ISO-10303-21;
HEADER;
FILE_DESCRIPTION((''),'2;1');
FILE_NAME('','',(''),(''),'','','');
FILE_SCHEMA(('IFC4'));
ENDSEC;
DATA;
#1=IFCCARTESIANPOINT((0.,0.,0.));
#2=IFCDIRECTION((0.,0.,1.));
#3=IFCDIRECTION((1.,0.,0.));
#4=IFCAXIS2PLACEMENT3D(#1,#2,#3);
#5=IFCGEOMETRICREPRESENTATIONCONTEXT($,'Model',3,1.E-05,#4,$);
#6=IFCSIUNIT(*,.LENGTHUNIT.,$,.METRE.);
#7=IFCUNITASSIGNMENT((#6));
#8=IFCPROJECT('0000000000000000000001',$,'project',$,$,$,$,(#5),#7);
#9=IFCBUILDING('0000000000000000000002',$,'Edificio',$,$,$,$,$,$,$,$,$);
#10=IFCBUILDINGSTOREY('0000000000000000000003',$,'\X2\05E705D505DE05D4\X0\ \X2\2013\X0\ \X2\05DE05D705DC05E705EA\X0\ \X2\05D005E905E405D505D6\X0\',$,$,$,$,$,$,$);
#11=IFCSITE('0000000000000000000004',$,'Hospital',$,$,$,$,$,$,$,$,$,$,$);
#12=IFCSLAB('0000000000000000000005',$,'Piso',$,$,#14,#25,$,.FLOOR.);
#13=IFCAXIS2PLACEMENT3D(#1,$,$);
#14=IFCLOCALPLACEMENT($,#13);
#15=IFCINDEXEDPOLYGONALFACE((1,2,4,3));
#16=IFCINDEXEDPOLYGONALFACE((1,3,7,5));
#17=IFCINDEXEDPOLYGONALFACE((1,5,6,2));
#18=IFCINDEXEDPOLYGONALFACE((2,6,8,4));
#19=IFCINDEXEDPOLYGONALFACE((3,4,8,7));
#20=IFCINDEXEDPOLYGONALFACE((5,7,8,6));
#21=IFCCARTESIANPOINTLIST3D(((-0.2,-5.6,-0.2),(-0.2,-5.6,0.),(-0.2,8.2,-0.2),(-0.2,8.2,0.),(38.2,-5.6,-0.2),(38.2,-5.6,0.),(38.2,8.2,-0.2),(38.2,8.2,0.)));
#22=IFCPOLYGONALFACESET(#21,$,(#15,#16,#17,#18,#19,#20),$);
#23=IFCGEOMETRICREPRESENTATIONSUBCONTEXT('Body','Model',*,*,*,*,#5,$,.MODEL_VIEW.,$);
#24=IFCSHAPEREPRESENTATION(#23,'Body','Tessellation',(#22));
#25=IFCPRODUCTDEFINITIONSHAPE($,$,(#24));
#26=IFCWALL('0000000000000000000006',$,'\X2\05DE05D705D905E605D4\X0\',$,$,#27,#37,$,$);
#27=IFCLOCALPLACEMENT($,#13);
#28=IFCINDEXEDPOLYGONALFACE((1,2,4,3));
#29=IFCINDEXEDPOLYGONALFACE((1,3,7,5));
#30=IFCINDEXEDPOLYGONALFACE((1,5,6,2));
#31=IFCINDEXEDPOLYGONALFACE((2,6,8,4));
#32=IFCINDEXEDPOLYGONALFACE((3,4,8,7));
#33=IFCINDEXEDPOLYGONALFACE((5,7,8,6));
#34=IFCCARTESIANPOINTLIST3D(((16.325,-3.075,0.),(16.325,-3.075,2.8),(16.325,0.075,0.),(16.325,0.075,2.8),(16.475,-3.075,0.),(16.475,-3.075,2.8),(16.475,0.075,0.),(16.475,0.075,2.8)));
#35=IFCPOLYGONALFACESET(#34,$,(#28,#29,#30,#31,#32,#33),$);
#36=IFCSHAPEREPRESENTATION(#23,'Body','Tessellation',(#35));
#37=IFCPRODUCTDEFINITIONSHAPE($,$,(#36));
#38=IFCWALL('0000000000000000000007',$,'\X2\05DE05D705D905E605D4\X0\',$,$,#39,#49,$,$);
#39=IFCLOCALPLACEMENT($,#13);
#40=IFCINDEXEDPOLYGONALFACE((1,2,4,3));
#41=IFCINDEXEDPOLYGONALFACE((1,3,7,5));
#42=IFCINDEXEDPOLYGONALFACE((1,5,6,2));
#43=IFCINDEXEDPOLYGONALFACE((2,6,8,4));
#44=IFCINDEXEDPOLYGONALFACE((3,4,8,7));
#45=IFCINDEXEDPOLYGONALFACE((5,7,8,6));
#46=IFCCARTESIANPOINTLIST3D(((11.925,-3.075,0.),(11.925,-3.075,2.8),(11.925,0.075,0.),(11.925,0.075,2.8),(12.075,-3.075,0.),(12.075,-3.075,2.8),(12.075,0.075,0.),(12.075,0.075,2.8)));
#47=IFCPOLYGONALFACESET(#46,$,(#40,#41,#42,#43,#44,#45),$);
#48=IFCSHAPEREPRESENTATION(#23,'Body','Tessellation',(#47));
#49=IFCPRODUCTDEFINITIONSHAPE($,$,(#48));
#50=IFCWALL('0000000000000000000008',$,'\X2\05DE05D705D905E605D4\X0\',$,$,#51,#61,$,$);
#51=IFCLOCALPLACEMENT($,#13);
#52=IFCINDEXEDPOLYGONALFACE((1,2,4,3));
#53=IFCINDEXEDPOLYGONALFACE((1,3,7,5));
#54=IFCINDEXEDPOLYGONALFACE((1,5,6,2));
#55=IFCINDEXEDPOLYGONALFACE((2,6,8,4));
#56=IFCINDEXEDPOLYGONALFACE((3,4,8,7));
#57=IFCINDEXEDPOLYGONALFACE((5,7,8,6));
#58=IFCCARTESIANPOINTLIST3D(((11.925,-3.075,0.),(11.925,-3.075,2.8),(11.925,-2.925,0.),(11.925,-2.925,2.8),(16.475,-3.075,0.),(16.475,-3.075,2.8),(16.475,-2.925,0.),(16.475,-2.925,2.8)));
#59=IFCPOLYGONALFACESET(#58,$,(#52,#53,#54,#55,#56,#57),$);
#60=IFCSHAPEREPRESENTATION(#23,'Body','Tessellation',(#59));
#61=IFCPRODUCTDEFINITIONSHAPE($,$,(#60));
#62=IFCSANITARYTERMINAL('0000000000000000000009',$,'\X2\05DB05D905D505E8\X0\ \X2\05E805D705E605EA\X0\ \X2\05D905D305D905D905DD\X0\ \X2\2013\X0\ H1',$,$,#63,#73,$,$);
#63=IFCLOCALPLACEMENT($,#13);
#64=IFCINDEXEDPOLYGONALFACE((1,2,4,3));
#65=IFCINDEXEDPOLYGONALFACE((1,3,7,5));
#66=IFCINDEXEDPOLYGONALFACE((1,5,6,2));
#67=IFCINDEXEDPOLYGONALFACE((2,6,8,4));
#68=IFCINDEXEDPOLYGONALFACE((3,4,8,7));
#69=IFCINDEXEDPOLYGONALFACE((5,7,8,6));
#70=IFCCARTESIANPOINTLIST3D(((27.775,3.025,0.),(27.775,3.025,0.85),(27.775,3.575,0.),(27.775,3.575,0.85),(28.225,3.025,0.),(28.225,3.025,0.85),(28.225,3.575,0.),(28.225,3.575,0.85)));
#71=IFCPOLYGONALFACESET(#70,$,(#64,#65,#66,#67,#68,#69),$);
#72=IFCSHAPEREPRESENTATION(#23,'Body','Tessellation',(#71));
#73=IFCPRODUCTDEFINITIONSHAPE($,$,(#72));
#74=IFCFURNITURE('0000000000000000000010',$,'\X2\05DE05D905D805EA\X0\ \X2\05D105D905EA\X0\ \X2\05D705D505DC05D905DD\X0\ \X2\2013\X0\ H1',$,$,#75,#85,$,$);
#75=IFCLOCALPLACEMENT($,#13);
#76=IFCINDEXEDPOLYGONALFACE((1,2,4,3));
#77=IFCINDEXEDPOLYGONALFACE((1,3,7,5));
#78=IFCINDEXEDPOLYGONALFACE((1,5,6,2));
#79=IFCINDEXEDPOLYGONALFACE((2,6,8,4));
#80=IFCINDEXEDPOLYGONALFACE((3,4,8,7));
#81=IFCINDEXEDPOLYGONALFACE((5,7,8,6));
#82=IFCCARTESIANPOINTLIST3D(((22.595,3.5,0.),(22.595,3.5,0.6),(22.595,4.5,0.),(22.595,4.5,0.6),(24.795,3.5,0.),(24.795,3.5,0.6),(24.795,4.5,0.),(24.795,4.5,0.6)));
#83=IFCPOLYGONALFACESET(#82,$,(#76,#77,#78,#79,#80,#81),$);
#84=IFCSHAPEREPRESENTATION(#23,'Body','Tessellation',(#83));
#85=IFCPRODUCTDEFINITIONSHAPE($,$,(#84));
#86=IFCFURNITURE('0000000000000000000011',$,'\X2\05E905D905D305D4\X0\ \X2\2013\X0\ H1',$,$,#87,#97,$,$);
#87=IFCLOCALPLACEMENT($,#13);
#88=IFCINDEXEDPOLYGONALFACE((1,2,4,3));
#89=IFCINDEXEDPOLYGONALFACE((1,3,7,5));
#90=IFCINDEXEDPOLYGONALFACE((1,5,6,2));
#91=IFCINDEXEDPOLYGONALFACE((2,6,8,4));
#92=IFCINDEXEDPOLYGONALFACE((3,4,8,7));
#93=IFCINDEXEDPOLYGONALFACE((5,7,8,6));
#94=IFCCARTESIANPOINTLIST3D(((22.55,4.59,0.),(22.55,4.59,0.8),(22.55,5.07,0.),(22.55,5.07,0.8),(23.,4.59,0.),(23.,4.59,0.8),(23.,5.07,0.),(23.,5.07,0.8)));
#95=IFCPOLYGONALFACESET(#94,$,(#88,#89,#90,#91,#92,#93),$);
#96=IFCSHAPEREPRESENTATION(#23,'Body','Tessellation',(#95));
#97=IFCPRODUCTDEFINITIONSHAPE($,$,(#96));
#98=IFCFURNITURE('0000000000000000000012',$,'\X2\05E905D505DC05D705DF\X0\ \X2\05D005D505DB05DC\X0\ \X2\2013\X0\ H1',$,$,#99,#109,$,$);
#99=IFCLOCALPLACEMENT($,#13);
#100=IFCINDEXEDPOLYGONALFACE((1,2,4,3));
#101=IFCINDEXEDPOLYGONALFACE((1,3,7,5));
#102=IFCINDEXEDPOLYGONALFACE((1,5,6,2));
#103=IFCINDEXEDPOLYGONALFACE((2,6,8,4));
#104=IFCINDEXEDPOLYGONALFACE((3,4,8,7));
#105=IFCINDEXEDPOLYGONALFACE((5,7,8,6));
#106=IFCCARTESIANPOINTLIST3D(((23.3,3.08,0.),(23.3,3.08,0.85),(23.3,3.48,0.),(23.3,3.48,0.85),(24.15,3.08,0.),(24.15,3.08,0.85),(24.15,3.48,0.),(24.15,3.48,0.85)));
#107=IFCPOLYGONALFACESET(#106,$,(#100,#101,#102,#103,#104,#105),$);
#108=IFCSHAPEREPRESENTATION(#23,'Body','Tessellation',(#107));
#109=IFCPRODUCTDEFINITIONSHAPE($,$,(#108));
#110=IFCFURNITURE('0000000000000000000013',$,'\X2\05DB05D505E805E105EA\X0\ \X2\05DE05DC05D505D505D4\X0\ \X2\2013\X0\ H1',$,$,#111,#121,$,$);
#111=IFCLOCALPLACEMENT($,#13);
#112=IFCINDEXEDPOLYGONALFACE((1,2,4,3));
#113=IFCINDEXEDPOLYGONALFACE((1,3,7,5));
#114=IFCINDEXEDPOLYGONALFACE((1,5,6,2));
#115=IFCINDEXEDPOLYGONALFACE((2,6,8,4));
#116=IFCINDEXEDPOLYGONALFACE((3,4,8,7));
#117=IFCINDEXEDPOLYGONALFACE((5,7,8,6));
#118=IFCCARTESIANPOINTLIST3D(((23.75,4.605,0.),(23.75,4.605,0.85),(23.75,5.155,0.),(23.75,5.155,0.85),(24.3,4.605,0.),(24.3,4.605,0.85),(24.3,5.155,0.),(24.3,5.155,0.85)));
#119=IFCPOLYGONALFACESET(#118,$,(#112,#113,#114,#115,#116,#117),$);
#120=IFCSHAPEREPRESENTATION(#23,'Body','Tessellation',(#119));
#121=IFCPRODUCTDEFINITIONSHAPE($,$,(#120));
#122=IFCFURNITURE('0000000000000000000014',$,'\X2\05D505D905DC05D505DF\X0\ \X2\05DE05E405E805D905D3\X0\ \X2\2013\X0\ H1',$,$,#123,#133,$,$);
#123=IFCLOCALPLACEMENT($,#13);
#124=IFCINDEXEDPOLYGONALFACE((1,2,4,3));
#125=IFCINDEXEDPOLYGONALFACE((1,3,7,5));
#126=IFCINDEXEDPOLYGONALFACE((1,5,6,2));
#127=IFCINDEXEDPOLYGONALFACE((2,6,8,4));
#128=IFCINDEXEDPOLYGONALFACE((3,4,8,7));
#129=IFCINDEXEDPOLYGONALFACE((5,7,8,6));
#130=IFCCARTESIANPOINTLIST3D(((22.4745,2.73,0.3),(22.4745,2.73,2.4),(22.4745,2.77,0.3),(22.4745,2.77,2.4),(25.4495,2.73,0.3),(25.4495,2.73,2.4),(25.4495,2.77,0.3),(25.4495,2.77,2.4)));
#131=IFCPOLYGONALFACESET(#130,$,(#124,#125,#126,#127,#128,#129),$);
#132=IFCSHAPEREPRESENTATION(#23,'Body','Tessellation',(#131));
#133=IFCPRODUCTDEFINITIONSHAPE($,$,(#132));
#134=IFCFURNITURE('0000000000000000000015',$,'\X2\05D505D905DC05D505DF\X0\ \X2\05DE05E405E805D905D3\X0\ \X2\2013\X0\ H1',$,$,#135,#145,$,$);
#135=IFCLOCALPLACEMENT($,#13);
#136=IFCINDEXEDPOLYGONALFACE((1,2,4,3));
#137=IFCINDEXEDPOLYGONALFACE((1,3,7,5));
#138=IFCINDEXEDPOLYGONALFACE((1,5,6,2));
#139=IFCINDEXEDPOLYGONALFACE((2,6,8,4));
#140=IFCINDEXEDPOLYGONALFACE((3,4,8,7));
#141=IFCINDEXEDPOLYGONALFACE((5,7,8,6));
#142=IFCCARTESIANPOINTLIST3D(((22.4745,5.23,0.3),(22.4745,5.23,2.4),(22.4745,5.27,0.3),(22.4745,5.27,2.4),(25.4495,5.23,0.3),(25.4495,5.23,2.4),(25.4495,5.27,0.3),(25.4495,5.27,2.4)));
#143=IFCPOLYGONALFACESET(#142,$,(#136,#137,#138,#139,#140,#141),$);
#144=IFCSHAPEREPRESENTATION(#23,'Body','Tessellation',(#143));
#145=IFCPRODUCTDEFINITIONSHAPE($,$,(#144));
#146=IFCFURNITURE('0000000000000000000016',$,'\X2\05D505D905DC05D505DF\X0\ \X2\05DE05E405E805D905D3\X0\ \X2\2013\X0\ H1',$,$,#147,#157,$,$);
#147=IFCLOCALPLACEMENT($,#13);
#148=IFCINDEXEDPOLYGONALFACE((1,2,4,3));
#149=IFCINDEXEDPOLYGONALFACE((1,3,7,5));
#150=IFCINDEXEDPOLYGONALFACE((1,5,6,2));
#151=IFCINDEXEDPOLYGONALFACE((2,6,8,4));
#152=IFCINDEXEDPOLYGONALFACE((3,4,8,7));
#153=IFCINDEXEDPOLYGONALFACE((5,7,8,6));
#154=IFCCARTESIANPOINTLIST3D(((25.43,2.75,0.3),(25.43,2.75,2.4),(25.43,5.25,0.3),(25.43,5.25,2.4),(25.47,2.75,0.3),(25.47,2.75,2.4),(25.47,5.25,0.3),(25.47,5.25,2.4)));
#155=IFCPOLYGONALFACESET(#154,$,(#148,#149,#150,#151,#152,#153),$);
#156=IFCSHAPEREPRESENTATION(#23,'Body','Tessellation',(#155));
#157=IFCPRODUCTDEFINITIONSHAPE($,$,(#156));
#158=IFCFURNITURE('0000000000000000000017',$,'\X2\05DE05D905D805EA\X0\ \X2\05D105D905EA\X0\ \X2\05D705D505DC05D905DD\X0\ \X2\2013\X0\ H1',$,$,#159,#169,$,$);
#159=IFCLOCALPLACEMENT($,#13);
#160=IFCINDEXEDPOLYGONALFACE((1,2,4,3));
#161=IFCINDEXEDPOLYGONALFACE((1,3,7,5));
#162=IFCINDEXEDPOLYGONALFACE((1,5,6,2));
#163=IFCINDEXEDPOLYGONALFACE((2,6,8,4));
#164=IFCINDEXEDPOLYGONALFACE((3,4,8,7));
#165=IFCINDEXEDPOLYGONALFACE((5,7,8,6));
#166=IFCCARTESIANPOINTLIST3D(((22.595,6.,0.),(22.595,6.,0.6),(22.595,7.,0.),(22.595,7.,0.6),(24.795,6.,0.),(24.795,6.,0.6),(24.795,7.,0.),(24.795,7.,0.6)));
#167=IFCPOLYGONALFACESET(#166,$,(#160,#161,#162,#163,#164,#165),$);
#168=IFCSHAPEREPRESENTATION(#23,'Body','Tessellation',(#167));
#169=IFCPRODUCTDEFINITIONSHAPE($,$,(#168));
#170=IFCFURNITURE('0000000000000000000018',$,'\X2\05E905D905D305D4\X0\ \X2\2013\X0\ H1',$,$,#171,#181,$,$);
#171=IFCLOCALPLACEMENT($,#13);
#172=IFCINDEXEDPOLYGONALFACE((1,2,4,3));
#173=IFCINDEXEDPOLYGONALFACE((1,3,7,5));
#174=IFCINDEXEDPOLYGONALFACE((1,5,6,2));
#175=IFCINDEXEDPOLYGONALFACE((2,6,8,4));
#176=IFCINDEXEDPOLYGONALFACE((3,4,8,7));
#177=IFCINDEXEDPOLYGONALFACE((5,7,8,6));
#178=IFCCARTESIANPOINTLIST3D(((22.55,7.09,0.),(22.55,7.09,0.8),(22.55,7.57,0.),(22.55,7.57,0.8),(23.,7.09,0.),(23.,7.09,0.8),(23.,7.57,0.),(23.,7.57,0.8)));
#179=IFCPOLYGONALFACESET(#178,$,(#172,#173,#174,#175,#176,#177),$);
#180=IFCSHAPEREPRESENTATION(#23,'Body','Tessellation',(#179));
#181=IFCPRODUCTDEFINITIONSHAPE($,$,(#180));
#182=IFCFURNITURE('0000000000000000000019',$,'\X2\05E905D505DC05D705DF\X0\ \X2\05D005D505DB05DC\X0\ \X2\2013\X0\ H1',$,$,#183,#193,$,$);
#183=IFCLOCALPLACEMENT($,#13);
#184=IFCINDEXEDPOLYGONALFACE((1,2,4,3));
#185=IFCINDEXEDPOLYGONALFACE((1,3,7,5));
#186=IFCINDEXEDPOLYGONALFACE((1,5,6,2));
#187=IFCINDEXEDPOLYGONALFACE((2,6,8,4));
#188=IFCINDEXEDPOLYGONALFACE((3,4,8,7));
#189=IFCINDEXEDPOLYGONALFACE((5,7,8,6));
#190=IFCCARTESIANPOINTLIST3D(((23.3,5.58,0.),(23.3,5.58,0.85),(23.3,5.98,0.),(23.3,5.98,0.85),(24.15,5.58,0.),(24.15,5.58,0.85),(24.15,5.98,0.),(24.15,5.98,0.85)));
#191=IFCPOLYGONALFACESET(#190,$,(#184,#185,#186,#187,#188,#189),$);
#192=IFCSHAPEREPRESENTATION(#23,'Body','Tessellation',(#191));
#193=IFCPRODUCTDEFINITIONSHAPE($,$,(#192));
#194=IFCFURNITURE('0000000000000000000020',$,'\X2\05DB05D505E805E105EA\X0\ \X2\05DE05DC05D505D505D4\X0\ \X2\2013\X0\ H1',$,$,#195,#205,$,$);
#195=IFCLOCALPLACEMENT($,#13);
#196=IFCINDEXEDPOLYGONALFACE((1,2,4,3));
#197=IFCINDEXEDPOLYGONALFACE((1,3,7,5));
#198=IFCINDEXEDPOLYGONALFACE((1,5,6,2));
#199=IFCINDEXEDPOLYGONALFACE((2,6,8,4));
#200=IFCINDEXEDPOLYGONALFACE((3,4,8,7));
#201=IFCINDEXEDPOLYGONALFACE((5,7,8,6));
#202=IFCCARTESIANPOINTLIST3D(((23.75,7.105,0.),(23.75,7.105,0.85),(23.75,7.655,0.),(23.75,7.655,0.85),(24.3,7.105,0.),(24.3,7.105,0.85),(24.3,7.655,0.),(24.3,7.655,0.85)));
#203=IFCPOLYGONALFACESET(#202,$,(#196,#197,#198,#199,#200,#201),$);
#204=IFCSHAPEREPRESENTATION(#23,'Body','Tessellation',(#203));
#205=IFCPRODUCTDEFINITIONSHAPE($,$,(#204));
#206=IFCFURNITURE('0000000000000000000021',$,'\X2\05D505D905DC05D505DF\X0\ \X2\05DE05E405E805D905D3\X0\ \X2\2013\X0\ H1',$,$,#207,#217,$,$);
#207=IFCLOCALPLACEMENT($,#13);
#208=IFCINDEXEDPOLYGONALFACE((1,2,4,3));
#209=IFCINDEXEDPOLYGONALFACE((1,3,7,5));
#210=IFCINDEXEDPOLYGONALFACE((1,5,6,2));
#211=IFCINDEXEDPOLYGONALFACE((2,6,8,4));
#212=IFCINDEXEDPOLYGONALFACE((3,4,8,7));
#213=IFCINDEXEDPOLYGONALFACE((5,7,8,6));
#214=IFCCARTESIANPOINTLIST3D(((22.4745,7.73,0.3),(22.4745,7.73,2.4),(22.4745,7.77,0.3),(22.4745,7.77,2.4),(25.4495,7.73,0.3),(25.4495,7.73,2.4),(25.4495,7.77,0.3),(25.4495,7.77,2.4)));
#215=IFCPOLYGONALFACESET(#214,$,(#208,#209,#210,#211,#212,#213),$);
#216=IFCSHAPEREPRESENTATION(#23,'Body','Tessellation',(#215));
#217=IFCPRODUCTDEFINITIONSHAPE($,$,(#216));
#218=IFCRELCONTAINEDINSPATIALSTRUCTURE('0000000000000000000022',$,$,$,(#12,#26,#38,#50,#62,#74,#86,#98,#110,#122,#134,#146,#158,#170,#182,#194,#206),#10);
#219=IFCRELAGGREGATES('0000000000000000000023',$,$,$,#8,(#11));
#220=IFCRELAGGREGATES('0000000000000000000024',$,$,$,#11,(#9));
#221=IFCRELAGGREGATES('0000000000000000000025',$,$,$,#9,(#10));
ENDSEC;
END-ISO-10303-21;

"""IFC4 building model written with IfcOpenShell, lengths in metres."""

from ifc_helpers import new_model, si_unit, frame, origin_with_axes, context, subcontext, project, spatial, line, indexed_curve, outline, extrude, element, save


model = new_model("IFC4")

# Units and contexts
model_context = context("Model", 3, precision=1e-05, world=origin_with_axes())
body_context = subcontext(model_context, "Body", "Model", "MODEL_VIEW")
ifc_project = project(units=[si_unit("LENGTHUNIT", "METRE")], contexts=[model_context])

# Site, building, storey
site = spatial("IfcSite", under=ifc_project, Name="Hospital")
building = spatial("IfcBuilding", under=site, Name="Edificio")
storey = spatial("IfcBuildingStorey", under=building, Name="קומה – מחלקת אשפוז")

# Slab
element("IfcSlab", 1, inside=storey, Name="Piso", PredefinedType="FLOOR", context=body_context, shape_type="SweptSolid", body=[
    extrude(outline(indexed_curve([(0.0, 0.0), (38.4, 0.0), (38.4, 13.8), (0.0, 13.8)], segments=[line(1, 2, 3, 4, 1)])), frame((-0.2, -5.6, -0.2), z_axis=(0.0, 0.0, 1.0), x_axis=(1.0, 0.0, 0.0)), (0.0, 0.0, 1.0), 0.2),
])

# Walls
element("IfcWall", 2, inside=storey, Name="מחיצה", context=body_context, shape_type="SweptSolid", body=[
    extrude(outline(indexed_curve([(0.0, 0.0), (0.15, 0.0), (0.15, 3.15), (0.0, 3.15)], segments=[line(1, 2, 3, 4, 1)])), frame((16.325, -3.075, 0.0), z_axis=(0.0, 0.0, 1.0), x_axis=(1.0, 0.0, 0.0)), (0.0, 0.0, 1.0), 2.8),
])
element("IfcWall", 3, inside=storey, Name="מחיצה", context=body_context, shape_type="SweptSolid", body=[
    extrude(outline(indexed_curve([(0.0, 0.0), (0.15, 0.0), (0.15, 3.15), (0.0, 3.15)], segments=[line(1, 2, 3, 4, 1)])), frame((11.925, -3.075, 0.0), z_axis=(0.0, 0.0, 1.0), x_axis=(1.0, 0.0, 0.0)), (0.0, 0.0, 1.0), 2.8),
])
element("IfcWall", 4, inside=storey, Name="מחיצה", context=body_context, shape_type="SweptSolid", body=[
    extrude(outline(indexed_curve([(0.0, 0.0), (4.55, 0.0), (4.55, 0.15), (0.0, 0.15)], segments=[line(1, 2, 3, 4, 1)])), frame((11.925, -3.075, 0.0), z_axis=(0.0, 0.0, 1.0), x_axis=(1.0, 0.0, 0.0)), (0.0, 0.0, 1.0), 2.8),
])

# Sanitary terminal
element("IfcSanitaryTerminal", 5, inside=storey, Name="כיור רחצת ידיים – H1", context=body_context, shape_type="SweptSolid", body=[
    extrude(outline(indexed_curve([(0.0, 0.0), (0.45, 0.0), (0.45, 0.55), (0.0, 0.55)], segments=[line(1, 2, 3, 4, 1)])), frame((27.775, 3.025, 0.0), z_axis=(0.0, 0.0, 1.0), x_axis=(1.0, 0.0, 0.0)), (0.0, 0.0, 1.0), 0.85),
])

# Furniture
element("IfcFurniture", 6, inside=storey, Name="מיטת בית חולים – H1", context=body_context, shape_type="SweptSolid", body=[
    extrude(outline(indexed_curve([(0.0, 0.0), (2.2, 0.0), (2.2, 1.0), (0.0, 1.0)], segments=[line(1, 2, 3, 4, 1)])), frame((22.595, 3.5, 0.0), z_axis=(0.0, 0.0, 1.0), x_axis=(1.0, 0.0, 0.0)), (0.0, 0.0, 1.0), 0.6),
])
element("IfcFurniture", 7, inside=storey, Name="שידה – H1", context=body_context, shape_type="SweptSolid", body=[
    extrude(outline(indexed_curve([(0.0, 0.0), (0.45, 0.0), (0.45, 0.48), (0.0, 0.48)], segments=[line(1, 2, 3, 4, 1)])), frame((22.55, 4.59, 0.0), z_axis=(0.0, 0.0, 1.0), x_axis=(1.0, 0.0, 0.0)), (0.0, 0.0, 1.0), 0.8),
])
element("IfcFurniture", 8, inside=storey, Name="שולחן אוכל – H1", context=body_context, shape_type="SweptSolid", body=[
    extrude(outline(indexed_curve([(0.0, 0.0), (0.85, 0.0), (0.85, 0.4), (0.0, 0.4)], segments=[line(1, 2, 3, 4, 1)])), frame((23.3, 3.08, 0.0), z_axis=(0.0, 0.0, 1.0), x_axis=(1.0, 0.0, 0.0)), (0.0, 0.0, 1.0), 0.85),
])
element("IfcFurniture", 9, inside=storey, Name="כורסת מלווה – H1", context=body_context, shape_type="SweptSolid", body=[
    extrude(outline(indexed_curve([(0.0, 0.0), (0.55, 0.0), (0.55, 0.55), (0.0, 0.55)], segments=[line(1, 2, 3, 4, 1)])), frame((23.75, 4.605, 0.0), z_axis=(0.0, 0.0, 1.0), x_axis=(1.0, 0.0, 0.0)), (0.0, 0.0, 1.0), 0.85),
])
element("IfcFurniture", 10, inside=storey, Name="וילון מפריד – H1", context=body_context, shape_type="SweptSolid", body=[
    extrude(outline(indexed_curve([(0.0, 0.0), (2.975, 0.0), (2.975, 0.04), (0.0, 0.04)], segments=[line(1, 2, 3, 4, 1)])), frame((22.4745, 2.73, 0.3), z_axis=(0.0, 0.0, 1.0), x_axis=(1.0, 0.0, 0.0)), (0.0, 0.0, 1.0), 2.1),
])
element("IfcFurniture", 11, inside=storey, Name="וילון מפריד – H1", context=body_context, shape_type="SweptSolid", body=[
    extrude(outline(indexed_curve([(0.0, 0.0), (2.975, 0.0), (2.975, 0.04), (0.0, 0.04)], segments=[line(1, 2, 3, 4, 1)])), frame((22.4745, 5.23, 0.3), z_axis=(0.0, 0.0, 1.0), x_axis=(1.0, 0.0, 0.0)), (0.0, 0.0, 1.0), 2.1),
])
element("IfcFurniture", 12, inside=storey, Name="וילון מפריד – H1", context=body_context, shape_type="SweptSolid", body=[
    extrude(outline(indexed_curve([(0.0, 0.0), (0.04, 0.0), (0.04, 2.5), (0.0, 2.5)], segments=[line(1, 2, 3, 4, 1)])), frame((25.43, 2.75, 0.3), z_axis=(0.0, 0.0, 1.0), x_axis=(1.0, 0.0, 0.0)), (0.0, 0.0, 1.0), 2.1),
])
element("IfcFurniture", 13, inside=storey, Name="מיטת בית חולים – H1", context=body_context, shape_type="SweptSolid", body=[
    extrude(outline(indexed_curve([(0.0, 0.0), (2.2, 0.0), (2.2, 1.0), (0.0, 1.0)], segments=[line(1, 2, 3, 4, 1)])), frame((22.595, 6.0, 0.0), z_axis=(0.0, 0.0, 1.0), x_axis=(1.0, 0.0, 0.0)), (0.0, 0.0, 1.0), 0.6),
])
element("IfcFurniture", 14, inside=storey, Name="שידה – H1", context=body_context, shape_type="SweptSolid", body=[
    extrude(outline(indexed_curve([(0.0, 0.0), (0.45, 0.0), (0.45, 0.48), (0.0, 0.48)], segments=[line(1, 2, 3, 4, 1)])), frame((22.55, 7.09, 0.0), z_axis=(0.0, 0.0, 1.0), x_axis=(1.0, 0.0, 0.0)), (0.0, 0.0, 1.0), 0.8),
])
element("IfcFurniture", 15, inside=storey, Name="שולחן אוכל – H1", context=body_context, shape_type="SweptSolid", body=[
    extrude(outline(indexed_curve([(0.0, 0.0), (0.85, 0.0), (0.85, 0.4), (0.0, 0.4)], segments=[line(1, 2, 3, 4, 1)])), frame((23.3, 5.58, 0.0), z_axis=(0.0, 0.0, 1.0), x_axis=(1.0, 0.0, 0.0)), (0.0, 0.0, 1.0), 0.85),
])
element("IfcFurniture", 16, inside=storey, Name="כורסת מלווה – H1", context=body_context, shape_type="SweptSolid", body=[
    extrude(outline(indexed_curve([(0.0, 0.0), (0.55, 0.0), (0.55, 0.55), (0.0, 0.55)], segments=[line(1, 2, 3, 4, 1)])), frame((23.75, 7.105, 0.0), z_axis=(0.0, 0.0, 1.0), x_axis=(1.0, 0.0, 0.0)), (0.0, 0.0, 1.0), 0.85),
])
element("IfcFurniture", 17, inside=storey, Name="וילון מפריד – H1", context=body_context, shape_type="SweptSolid", body=[
    extrude(outline(indexed_curve([(0.0, 0.0), (2.975, 0.0), (2.975, 0.04), (0.0, 0.04)], segments=[line(1, 2, 3, 4, 1)])), frame((22.4745, 7.73, 0.3), z_axis=(0.0, 0.0, 1.0), x_axis=(1.0, 0.0, 0.0)), (0.0, 0.0, 1.0), 2.1),
])

save(model, "model.ifc")
